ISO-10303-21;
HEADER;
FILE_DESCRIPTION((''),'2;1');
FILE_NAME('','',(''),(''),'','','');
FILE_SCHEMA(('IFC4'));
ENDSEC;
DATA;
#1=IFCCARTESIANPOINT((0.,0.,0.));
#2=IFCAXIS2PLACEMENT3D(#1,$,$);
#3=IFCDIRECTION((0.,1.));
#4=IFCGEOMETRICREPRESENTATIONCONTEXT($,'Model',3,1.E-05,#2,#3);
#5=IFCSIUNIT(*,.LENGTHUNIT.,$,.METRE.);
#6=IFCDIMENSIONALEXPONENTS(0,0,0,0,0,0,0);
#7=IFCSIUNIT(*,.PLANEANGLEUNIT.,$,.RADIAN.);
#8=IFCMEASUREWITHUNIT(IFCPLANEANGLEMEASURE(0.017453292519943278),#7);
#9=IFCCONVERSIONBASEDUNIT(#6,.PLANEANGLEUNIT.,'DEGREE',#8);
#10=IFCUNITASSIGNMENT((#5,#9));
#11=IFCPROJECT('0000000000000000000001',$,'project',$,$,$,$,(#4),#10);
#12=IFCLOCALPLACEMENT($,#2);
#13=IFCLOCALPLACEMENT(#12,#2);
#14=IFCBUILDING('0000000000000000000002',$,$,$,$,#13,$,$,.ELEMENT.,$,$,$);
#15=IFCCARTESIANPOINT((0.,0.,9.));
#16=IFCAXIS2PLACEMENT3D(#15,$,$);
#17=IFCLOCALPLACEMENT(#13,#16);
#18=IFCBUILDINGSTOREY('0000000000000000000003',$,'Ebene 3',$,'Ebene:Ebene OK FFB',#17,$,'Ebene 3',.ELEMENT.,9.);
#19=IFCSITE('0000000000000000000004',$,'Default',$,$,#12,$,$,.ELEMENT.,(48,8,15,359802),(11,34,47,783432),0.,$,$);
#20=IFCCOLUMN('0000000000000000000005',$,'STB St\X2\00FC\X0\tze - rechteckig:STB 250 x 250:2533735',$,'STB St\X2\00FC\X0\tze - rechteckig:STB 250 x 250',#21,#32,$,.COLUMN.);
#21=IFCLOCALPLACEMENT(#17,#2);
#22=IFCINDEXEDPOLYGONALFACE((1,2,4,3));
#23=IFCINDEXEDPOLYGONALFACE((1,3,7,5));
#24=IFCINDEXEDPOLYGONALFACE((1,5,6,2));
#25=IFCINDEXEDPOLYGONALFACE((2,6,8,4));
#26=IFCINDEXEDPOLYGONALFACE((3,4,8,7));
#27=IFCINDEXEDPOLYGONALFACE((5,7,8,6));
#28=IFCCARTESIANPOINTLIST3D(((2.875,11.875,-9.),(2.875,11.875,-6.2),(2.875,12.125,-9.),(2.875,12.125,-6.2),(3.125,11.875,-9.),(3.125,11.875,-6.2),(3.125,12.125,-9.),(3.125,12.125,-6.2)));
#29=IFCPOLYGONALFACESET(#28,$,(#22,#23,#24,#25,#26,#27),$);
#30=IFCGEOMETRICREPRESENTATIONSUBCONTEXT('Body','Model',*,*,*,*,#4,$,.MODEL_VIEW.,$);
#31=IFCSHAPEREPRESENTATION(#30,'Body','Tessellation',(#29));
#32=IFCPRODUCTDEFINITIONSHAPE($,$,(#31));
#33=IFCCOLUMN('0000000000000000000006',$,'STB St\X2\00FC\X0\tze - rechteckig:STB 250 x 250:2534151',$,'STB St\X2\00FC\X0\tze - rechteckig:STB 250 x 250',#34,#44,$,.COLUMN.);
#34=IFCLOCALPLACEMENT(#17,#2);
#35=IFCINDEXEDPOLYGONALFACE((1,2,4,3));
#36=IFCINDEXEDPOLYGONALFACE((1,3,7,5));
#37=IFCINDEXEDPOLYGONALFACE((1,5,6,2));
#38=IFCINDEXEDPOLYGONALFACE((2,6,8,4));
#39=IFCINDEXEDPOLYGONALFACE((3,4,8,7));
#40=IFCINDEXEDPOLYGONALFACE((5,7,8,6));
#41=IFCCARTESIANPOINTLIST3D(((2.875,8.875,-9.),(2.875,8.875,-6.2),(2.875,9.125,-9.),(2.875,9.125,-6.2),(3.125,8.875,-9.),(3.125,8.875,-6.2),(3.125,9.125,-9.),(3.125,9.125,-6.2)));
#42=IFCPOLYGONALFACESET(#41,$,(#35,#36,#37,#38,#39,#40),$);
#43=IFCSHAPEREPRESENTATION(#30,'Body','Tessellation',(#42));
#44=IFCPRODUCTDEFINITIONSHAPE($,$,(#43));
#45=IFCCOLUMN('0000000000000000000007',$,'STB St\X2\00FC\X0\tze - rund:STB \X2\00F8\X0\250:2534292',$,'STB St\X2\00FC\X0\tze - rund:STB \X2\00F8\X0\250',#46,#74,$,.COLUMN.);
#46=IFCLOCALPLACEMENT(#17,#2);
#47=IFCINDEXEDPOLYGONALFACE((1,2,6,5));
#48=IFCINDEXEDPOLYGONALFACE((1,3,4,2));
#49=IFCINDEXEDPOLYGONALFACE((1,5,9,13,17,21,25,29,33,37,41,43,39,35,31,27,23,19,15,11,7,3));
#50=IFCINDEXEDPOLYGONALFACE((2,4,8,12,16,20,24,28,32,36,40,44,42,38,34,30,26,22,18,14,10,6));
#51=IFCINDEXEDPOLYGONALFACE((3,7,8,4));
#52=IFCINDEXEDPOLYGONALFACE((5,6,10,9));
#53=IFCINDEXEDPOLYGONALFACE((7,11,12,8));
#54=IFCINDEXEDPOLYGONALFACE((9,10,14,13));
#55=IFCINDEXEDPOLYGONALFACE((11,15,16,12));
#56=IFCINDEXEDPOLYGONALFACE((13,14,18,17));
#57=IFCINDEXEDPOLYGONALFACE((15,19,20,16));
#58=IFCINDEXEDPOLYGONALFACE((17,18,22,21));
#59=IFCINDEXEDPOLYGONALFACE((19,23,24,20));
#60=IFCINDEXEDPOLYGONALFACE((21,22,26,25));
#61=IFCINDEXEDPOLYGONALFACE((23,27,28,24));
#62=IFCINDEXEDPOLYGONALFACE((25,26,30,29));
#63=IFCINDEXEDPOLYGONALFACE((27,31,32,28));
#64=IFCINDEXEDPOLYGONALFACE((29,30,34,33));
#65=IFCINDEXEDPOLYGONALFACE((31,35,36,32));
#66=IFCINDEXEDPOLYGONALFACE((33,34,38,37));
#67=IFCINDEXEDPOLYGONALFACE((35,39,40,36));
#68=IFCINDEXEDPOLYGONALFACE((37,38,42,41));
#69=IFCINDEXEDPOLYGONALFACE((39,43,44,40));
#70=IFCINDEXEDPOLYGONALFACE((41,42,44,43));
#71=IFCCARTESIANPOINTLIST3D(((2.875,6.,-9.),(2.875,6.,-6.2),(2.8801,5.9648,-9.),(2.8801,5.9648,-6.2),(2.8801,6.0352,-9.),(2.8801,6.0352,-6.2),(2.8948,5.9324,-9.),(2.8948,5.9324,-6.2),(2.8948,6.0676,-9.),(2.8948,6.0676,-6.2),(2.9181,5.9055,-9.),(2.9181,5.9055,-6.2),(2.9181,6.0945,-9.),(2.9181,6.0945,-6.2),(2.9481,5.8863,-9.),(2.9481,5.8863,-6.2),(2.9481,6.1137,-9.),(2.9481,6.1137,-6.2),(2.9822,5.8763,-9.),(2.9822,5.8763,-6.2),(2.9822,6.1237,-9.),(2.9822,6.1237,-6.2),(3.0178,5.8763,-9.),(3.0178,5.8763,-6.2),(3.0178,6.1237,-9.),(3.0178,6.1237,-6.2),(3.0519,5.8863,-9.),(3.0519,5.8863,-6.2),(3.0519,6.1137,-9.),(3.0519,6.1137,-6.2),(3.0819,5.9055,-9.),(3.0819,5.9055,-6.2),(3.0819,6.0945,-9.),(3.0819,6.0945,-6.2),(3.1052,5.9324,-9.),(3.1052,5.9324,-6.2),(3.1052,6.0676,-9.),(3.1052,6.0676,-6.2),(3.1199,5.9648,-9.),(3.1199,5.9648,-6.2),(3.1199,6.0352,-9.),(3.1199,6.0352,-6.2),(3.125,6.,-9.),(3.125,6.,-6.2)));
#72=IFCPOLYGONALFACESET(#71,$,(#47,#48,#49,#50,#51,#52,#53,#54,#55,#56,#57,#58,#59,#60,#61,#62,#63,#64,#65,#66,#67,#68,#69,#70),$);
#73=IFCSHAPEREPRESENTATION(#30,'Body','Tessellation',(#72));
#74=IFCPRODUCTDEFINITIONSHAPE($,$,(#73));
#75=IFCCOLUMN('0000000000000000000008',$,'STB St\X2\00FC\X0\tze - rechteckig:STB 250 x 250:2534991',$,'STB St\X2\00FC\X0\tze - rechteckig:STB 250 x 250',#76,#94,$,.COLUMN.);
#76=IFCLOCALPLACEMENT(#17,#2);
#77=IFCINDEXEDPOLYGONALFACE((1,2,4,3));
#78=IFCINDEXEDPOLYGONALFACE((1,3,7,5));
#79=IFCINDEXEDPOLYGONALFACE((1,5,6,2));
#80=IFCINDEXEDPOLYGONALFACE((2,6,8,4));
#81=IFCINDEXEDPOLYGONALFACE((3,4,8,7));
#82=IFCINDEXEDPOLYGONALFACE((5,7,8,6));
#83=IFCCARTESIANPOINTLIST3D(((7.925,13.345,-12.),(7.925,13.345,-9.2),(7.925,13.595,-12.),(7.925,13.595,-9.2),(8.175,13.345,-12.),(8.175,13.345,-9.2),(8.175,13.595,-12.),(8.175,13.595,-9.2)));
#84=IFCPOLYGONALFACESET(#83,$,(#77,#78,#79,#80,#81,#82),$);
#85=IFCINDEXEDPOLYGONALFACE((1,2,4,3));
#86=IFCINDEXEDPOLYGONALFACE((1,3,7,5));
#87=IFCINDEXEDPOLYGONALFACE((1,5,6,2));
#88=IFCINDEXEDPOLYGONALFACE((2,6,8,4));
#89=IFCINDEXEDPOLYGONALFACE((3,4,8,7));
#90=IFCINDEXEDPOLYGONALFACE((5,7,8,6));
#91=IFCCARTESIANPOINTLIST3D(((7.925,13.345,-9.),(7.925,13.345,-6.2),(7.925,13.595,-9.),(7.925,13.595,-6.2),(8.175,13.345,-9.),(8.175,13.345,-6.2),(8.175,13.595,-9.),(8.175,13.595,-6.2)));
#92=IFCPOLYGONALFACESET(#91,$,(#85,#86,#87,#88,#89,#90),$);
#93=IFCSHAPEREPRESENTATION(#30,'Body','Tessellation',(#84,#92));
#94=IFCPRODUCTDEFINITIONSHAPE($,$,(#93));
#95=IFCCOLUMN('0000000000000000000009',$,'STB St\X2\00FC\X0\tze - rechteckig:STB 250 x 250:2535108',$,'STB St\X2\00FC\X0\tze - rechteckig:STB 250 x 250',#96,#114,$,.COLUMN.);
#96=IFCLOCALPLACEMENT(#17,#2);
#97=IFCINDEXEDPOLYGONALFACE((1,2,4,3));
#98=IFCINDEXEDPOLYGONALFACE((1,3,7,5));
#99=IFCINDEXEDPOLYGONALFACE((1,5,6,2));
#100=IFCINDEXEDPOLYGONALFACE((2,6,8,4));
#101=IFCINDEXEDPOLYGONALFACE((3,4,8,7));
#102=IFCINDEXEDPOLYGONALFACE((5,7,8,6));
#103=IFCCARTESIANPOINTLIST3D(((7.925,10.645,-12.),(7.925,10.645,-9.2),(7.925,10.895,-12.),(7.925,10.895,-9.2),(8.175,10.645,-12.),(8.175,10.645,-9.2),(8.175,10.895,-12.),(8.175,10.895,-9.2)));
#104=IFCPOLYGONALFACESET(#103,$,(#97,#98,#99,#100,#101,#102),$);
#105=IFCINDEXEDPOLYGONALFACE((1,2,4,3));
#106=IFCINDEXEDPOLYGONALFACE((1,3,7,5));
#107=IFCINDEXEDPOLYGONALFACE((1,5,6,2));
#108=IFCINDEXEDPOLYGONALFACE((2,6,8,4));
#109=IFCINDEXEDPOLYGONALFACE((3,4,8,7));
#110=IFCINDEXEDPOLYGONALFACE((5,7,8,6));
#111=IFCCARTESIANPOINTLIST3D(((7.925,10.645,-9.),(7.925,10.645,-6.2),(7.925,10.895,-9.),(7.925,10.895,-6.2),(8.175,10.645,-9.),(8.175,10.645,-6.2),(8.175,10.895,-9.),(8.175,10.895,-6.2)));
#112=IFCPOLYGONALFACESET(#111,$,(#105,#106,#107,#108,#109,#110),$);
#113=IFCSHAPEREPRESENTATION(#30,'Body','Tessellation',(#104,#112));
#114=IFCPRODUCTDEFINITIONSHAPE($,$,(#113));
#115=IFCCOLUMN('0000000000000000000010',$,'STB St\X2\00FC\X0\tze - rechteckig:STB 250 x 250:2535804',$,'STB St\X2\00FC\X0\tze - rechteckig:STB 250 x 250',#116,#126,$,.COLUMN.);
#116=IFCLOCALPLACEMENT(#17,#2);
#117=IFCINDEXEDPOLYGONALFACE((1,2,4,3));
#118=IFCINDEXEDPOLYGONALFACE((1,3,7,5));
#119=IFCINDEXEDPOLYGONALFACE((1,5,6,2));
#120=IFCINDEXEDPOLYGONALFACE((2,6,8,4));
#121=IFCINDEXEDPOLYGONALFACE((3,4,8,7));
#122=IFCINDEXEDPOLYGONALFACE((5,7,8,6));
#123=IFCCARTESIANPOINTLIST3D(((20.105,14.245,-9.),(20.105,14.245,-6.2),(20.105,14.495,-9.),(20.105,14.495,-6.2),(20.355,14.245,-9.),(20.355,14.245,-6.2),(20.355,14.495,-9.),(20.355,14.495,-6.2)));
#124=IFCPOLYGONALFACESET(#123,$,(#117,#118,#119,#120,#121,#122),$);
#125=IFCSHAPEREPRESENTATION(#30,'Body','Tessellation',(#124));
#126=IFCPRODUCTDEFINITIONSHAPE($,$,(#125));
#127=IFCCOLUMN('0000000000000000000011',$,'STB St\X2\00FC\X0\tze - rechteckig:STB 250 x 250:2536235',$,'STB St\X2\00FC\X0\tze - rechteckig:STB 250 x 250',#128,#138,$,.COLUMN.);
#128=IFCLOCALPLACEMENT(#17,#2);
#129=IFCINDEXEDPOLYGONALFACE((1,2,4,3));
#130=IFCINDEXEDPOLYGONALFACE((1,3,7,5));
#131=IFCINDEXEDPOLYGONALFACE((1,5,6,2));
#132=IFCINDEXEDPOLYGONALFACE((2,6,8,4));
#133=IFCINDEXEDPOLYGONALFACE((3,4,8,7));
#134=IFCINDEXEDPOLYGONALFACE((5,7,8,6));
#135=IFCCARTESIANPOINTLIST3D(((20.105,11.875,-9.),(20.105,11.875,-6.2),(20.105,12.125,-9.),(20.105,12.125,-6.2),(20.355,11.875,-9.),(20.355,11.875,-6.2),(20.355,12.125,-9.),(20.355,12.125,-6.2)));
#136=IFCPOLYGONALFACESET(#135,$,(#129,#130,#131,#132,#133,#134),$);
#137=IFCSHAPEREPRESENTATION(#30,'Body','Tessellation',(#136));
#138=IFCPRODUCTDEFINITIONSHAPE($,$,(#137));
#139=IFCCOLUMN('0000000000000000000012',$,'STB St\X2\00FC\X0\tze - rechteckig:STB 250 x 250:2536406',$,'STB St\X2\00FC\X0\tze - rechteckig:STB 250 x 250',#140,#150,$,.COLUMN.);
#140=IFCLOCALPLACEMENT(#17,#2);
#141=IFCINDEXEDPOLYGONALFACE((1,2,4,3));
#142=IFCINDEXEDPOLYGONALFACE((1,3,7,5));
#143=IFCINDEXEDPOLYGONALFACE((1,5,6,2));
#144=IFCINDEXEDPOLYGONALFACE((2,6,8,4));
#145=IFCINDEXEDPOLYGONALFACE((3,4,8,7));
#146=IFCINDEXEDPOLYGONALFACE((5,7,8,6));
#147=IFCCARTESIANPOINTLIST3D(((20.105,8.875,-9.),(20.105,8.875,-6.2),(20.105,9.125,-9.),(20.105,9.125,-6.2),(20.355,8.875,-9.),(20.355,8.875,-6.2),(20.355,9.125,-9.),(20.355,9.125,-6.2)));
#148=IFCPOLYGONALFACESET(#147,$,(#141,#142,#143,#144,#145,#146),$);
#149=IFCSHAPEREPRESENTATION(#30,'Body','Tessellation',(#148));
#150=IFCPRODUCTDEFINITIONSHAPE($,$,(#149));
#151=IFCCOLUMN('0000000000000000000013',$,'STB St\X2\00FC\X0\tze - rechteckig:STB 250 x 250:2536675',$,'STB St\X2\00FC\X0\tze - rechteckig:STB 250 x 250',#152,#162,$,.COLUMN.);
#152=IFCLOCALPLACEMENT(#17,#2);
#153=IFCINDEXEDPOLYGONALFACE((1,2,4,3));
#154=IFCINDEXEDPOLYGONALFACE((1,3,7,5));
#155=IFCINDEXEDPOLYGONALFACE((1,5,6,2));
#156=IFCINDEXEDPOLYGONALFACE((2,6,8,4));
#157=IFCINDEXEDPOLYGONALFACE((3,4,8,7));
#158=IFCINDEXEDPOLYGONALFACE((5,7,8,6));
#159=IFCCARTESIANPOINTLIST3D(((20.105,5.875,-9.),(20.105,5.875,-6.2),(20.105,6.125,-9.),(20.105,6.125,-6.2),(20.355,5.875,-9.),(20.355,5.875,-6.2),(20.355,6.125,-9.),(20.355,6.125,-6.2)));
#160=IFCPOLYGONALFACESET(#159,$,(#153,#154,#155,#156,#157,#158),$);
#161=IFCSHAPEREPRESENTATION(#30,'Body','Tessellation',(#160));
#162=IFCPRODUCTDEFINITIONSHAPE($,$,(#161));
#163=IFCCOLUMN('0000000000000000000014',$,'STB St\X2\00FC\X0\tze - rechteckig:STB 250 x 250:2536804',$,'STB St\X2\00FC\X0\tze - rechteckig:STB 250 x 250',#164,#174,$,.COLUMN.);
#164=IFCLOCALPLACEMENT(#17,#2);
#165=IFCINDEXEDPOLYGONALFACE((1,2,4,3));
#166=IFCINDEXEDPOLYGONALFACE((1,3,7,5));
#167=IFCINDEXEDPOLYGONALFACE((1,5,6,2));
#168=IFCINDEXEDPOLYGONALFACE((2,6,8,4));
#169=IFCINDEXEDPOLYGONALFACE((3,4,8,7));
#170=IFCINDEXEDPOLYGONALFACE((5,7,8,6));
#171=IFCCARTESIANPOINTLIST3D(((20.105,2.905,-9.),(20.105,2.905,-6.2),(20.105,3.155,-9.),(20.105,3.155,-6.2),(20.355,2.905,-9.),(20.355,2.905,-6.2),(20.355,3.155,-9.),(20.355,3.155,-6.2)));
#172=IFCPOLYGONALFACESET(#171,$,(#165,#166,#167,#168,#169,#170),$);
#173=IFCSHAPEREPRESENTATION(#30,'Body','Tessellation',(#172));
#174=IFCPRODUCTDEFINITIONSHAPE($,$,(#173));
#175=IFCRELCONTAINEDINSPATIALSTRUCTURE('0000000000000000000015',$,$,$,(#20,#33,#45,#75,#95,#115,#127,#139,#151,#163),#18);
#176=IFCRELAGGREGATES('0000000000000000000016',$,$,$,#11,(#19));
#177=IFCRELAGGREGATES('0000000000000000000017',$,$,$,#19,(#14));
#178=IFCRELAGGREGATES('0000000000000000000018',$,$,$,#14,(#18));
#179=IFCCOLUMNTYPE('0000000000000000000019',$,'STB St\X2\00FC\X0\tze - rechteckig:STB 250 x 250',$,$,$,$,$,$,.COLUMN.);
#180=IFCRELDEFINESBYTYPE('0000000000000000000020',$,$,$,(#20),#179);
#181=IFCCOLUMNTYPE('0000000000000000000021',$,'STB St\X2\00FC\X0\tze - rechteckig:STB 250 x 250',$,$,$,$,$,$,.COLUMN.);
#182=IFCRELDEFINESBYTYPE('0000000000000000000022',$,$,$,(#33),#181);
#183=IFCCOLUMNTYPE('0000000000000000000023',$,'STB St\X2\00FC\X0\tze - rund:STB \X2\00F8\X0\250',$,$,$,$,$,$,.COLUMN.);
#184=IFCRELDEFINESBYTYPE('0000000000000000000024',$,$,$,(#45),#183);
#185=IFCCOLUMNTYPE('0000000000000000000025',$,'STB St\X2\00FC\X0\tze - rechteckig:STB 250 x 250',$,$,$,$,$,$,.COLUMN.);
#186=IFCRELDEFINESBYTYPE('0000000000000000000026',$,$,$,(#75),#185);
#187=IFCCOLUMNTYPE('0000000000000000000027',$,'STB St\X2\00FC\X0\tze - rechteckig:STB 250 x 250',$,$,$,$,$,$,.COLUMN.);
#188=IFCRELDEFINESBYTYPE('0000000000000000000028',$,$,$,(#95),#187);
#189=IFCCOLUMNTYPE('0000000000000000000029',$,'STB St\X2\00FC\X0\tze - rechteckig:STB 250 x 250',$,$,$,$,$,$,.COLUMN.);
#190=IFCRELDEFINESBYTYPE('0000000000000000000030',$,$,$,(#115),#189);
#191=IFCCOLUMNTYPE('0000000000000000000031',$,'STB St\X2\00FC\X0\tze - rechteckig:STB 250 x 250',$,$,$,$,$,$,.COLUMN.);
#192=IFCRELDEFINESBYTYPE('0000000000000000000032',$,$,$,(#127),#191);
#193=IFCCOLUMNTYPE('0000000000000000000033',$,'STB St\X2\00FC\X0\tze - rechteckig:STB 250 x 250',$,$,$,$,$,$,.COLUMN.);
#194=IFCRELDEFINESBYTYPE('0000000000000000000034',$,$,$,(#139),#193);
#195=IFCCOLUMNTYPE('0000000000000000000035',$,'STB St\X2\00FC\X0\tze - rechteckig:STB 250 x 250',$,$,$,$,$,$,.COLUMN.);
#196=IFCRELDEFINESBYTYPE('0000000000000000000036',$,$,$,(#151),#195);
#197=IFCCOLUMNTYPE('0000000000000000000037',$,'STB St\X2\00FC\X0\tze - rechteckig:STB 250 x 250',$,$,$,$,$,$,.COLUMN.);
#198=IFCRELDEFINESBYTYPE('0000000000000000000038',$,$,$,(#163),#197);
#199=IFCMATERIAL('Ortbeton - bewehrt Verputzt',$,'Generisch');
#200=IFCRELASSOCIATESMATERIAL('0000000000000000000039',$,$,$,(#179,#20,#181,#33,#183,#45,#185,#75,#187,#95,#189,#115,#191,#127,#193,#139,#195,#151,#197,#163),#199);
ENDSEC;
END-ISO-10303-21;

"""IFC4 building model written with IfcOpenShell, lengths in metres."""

from ifc_helpers import new_model, entity, si_unit, converted_unit, direction, frame, origin, place, context, subcontext, project, spatial, arc, indexed_curve, outline, extrude, source, transform, mapped, material, type_object, type_shapes, element, save


model = new_model("IFC4")

# Units and contexts
model_context = context("Model", 3, precision=1e-05, world=origin(), true_north=direction((0.0, 1.0)))
body_context = subcontext(model_context, "Body", "Model", "MODEL_VIEW")
ifc_project = project(units=[si_unit("LENGTHUNIT", "METRE"), converted_unit("PLANEANGLEUNIT", "DEGREE", entity("IfcPlaneAngleMeasure", 0.017453292519943278), si_unit("PLANEANGLEUNIT", "RADIAN"), dimensions=[0, 0, 0, 0, 0, 0, 0])], contexts=[model_context])

# Site, building, storey
site_placement = place(None, origin())
site = spatial("IfcSite", under=ifc_project, at=site_placement, Name="Default", CompositionType="ELEMENT", RefLatitude=(48, 8, 15, 359802), RefLongitude=(11, 34, 47, 783432), RefElevation=0.0)
building_placement = place(site_placement, origin())
building = spatial("IfcBuilding", under=site, at=building_placement, CompositionType="ELEMENT")
storey_placement = place(building_placement, frame((0.0, 0.0, 9.0)))
storey = spatial("IfcBuildingStorey", under=building, at=storey_placement, Name="Ebene 3", ObjectType="Ebene:Ebene OK FFB", LongName="Ebene 3", CompositionType="ELEMENT", Elevation=9.0)

# Columns
ifc_material_1 = material(Name="Ortbeton - bewehrt Verputzt", Category="Generisch")
column_type_1 = type_object("IfcColumnType", Name="STB Stütze - rechteckig:STB 250 x 250", PredefinedType="COLUMN", material=ifc_material_1)
shared_shape_1 = source(origin(), body_context, "Body", "SweptSolid", [
    extrude(outline(indexed_curve([(-0.125, -0.125), (0.125, -0.125), (0.125, 0.125), (-0.125, 0.125), (-0.125, -0.125)], self_intersect=False)), frame((3.0, 12.0, 0.0), z_axis=(0.0, 0.0, 1.0), x_axis=(-1.0, 0.0, 0.0)), (0.0, 0.0, 1.0), 2.8),
])
type_shapes(column_type_1, [shared_shape_1])
column_1_placement = place(storey_placement, frame((0.0, 0.0, -9.0)))
element("IfcColumn", 1, at=column_1_placement, inside=storey, type_object=column_type_1, material=ifc_material_1, Name="STB Stütze - rechteckig:STB 250 x 250:2533735", ObjectType="STB Stütze - rechteckig:STB 250 x 250", PredefinedType="COLUMN", context=body_context, shape_type="MappedRepresentation", body=[
    mapped(shared_shape_1, transform((0.0, 0.0, 0.0), scale=1.0)),
])
column_type_2 = type_object("IfcColumnType", Name="STB Stütze - rechteckig:STB 250 x 250", PredefinedType="COLUMN", material=ifc_material_1)
shared_shape_2 = source(origin(), body_context, "Body", "SweptSolid", [
    extrude(outline(indexed_curve([(-0.125, -0.125), (0.125, -0.125), (0.125, 0.125), (-0.125, 0.125), (-0.125, -0.125)], self_intersect=False)), frame((3.0, 9.0, 0.0), z_axis=(0.0, 0.0, 1.0), x_axis=(-1.0, 0.0, 0.0)), (0.0, 0.0, 1.0), 2.8),
])
type_shapes(column_type_2, [shared_shape_2])
column_2_placement = place(storey_placement, frame((0.0, 0.0, -9.0)))
element("IfcColumn", 2, at=column_2_placement, inside=storey, type_object=column_type_2, material=ifc_material_1, Name="STB Stütze - rechteckig:STB 250 x 250:2534151", ObjectType="STB Stütze - rechteckig:STB 250 x 250", PredefinedType="COLUMN", context=body_context, shape_type="MappedRepresentation", body=[
    mapped(shared_shape_2, transform((0.0, 0.0, 0.0), scale=1.0)),
])
column_type_3 = type_object("IfcColumnType", Name="STB Stütze - rund:STB ø250", PredefinedType="COLUMN", material=ifc_material_1)
shared_shape_3 = source(origin(), body_context, "Body", "SweptSolid", [
    extrude(outline(indexed_curve([(0.125, 0.0), (0.0, 0.125), (-0.125, 0.0), (0.0, -0.125)], segments=[arc(1, 2, 3), arc(3, 4, 1)], self_intersect=False)), frame((3.0, 6.0, 0.0)), (0.0, 0.0, 1.0), 2.8),
])
type_shapes(column_type_3, [shared_shape_3])
column_3_placement = place(storey_placement, frame((0.0, 0.0, -9.0)))
element("IfcColumn", 3, at=column_3_placement, inside=storey, type_object=column_type_3, material=ifc_material_1, Name="STB Stütze - rund:STB ø250:2534292", ObjectType="STB Stütze - rund:STB ø250", PredefinedType="COLUMN", context=body_context, shape_type="MappedRepresentation", body=[
    mapped(shared_shape_3, transform((0.0, 0.0, 0.0), scale=1.0)),
])
column_type_4 = type_object("IfcColumnType", Name="STB Stütze - rechteckig:STB 250 x 250", PredefinedType="COLUMN", material=ifc_material_1)
shared_shape_4 = source(origin(), body_context, "Body", "SweptSolid", [
    extrude(outline(indexed_curve([(-0.125, -0.125), (0.125, -0.125), (0.125, 0.125), (-0.125, 0.125), (-0.125, -0.125)], self_intersect=False)), frame((8.05, 13.47, -3.0), z_axis=(0.0, 0.0, 1.0), x_axis=(-1.0, 0.0, 0.0)), (0.0, 0.0, 1.0), 2.8),
    extrude(outline(indexed_curve([(-0.125, -0.125), (0.125, -0.125), (0.125, 0.125), (-0.125, 0.125), (-0.125, -0.125)], self_intersect=False)), frame((8.05, 13.47, 0.0), z_axis=(0.0, 0.0, 1.0), x_axis=(0.0, -1.0, 0.0)), (0.0, 0.0, 1.0), 2.8),
])
type_shapes(column_type_4, [shared_shape_4])
column_4_placement = place(storey_placement, frame((0.0, 0.0, -9.0)))
element("IfcColumn", 4, at=column_4_placement, inside=storey, type_object=column_type_4, material=ifc_material_1, Name="STB Stütze - rechteckig:STB 250 x 250:2534991", ObjectType="STB Stütze - rechteckig:STB 250 x 250", PredefinedType="COLUMN", context=body_context, shape_type="MappedRepresentation", body=[
    mapped(shared_shape_4, transform((0.0, 0.0, 0.0), scale=1.0)),
])
column_type_5 = type_object("IfcColumnType", Name="STB Stütze - rechteckig:STB 250 x 250", PredefinedType="COLUMN", material=ifc_material_1)
shared_shape_5 = source(origin(), body_context, "Body", "SweptSolid", [
    extrude(outline(indexed_curve([(-0.125, -0.125), (0.125, -0.125), (0.125, 0.125), (-0.125, 0.125), (-0.125, -0.125)], self_intersect=False)), frame((8.05, 10.77, -3.0), z_axis=(0.0, 0.0, 1.0), x_axis=(-1.0, 0.0, 0.0)), (0.0, 0.0, 1.0), 2.8),
    extrude(outline(indexed_curve([(-0.125, -0.125), (0.125, -0.125), (0.125, 0.125), (-0.125, 0.125), (-0.125, -0.125)], self_intersect=False)), frame((8.05, 10.77, 0.0), z_axis=(0.0, 0.0, 1.0), x_axis=(0.0, -1.0, 0.0)), (0.0, 0.0, 1.0), 2.8),
])
type_shapes(column_type_5, [shared_shape_5])
column_5_placement = place(storey_placement, frame((0.0, 0.0, -9.0)))
element("IfcColumn", 5, at=column_5_placement, inside=storey, type_object=column_type_5, material=ifc_material_1, Name="STB Stütze - rechteckig:STB 250 x 250:2535108", ObjectType="STB Stütze - rechteckig:STB 250 x 250", PredefinedType="COLUMN", context=body_context, shape_type="MappedRepresentation", body=[
    mapped(shared_shape_5, transform((0.0, 0.0, 0.0), scale=1.0)),
])
column_type_6 = type_object("IfcColumnType", Name="STB Stütze - rechteckig:STB 250 x 250", PredefinedType="COLUMN", material=ifc_material_1)
shared_shape_6 = source(origin(), body_context, "Body", "SweptSolid", [
    extrude(outline(indexed_curve([(-0.125, -0.125), (0.125, -0.125), (0.125, 0.125), (-0.125, 0.125), (-0.125, -0.125)], self_intersect=False)), frame((20.23, 14.37, 0.0), z_axis=(0.0, 0.0, 1.0), x_axis=(-1.0, 0.0, 0.0)), (0.0, 0.0, 1.0), 2.8),
])
type_shapes(column_type_6, [shared_shape_6])
column_6_placement = place(storey_placement, frame((0.0, 0.0, -9.0)))
element("IfcColumn", 6, at=column_6_placement, inside=storey, type_object=column_type_6, material=ifc_material_1, Name="STB Stütze - rechteckig:STB 250 x 250:2535804", ObjectType="STB Stütze - rechteckig:STB 250 x 250", PredefinedType="COLUMN", context=body_context, shape_type="MappedRepresentation", body=[
    mapped(shared_shape_6, transform((0.0, 0.0, 0.0), scale=1.0)),
])
column_type_7 = type_object("IfcColumnType", Name="STB Stütze - rechteckig:STB 250 x 250", PredefinedType="COLUMN", material=ifc_material_1)
shared_shape_7 = source(origin(), body_context, "Body", "SweptSolid", [
    extrude(outline(indexed_curve([(-0.125, -0.125), (0.125, -0.125), (0.125, 0.125), (-0.125, 0.125), (-0.125, -0.125)], self_intersect=False)), frame((20.23, 12.0, 0.0), z_axis=(0.0, 0.0, 1.0), x_axis=(-1.0, 0.0, 0.0)), (0.0, 0.0, 1.0), 2.8),
])
type_shapes(column_type_7, [shared_shape_7])
column_7_placement = place(storey_placement, frame((0.0, 0.0, -9.0)))
element("IfcColumn", 7, at=column_7_placement, inside=storey, type_object=column_type_7, material=ifc_material_1, Name="STB Stütze - rechteckig:STB 250 x 250:2536235", ObjectType="STB Stütze - rechteckig:STB 250 x 250", PredefinedType="COLUMN", context=body_context, shape_type="MappedRepresentation", body=[
    mapped(shared_shape_7, transform((0.0, 0.0, 0.0), scale=1.0)),
])
column_type_8 = type_object("IfcColumnType", Name="STB Stütze - rechteckig:STB 250 x 250", PredefinedType="COLUMN", material=ifc_material_1)
shared_shape_8 = source(origin(), body_context, "Body", "SweptSolid", [
    extrude(outline(indexed_curve([(-0.125, -0.125), (0.125, -0.125), (0.125, 0.125), (-0.125, 0.125), (-0.125, -0.125)], self_intersect=False)), frame((20.23, 9.0, 0.0), z_axis=(0.0, 0.0, 1.0), x_axis=(-1.0, 0.0, 0.0)), (0.0, 0.0, 1.0), 2.8),
])
type_shapes(column_type_8, [shared_shape_8])
column_8_placement = place(storey_placement, frame((0.0, 0.0, -9.0)))
element("IfcColumn", 8, at=column_8_placement, inside=storey, type_object=column_type_8, material=ifc_material_1, Name="STB Stütze - rechteckig:STB 250 x 250:2536406", ObjectType="STB Stütze - rechteckig:STB 250 x 250", PredefinedType="COLUMN", context=body_context, shape_type="MappedRepresentation", body=[
    mapped(shared_shape_8, transform((0.0, 0.0, 0.0), scale=1.0)),
])
column_type_9 = type_object("IfcColumnType", Name="STB Stütze - rechteckig:STB 250 x 250", PredefinedType="COLUMN", material=ifc_material_1)
shared_shape_9 = source(origin(), body_context, "Body", "SweptSolid", [
    extrude(outline(indexed_curve([(-0.125, -0.125), (0.125, -0.125), (0.125, 0.125), (-0.125, 0.125), (-0.125, -0.125)], self_intersect=False)), frame((20.23, 6.0, 0.0), z_axis=(0.0, 0.0, 1.0), x_axis=(-1.0, 0.0, 0.0)), (0.0, 0.0, 1.0), 2.8),
])
type_shapes(column_type_9, [shared_shape_9])
column_9_placement = place(storey_placement, frame((0.0, 0.0, -9.0)))
element("IfcColumn", 9, at=column_9_placement, inside=storey, type_object=column_type_9, material=ifc_material_1, Name="STB Stütze - rechteckig:STB 250 x 250:2536675", ObjectType="STB Stütze - rechteckig:STB 250 x 250", PredefinedType="COLUMN", context=body_context, shape_type="MappedRepresentation", body=[
    mapped(shared_shape_9, transform((0.0, 0.0, 0.0), scale=1.0)),
])
column_type_10 = type_object("IfcColumnType", Name="STB Stütze - rechteckig:STB 250 x 250", PredefinedType="COLUMN", material=ifc_material_1)
shared_shape_10 = source(origin(), body_context, "Body", "SweptSolid", [
    extrude(outline(indexed_curve([(-0.125, -0.125), (0.125, -0.125), (0.125, 0.125), (-0.125, 0.125), (-0.125, -0.125)], self_intersect=False)), frame((20.23, 3.03, 0.0), z_axis=(0.0, 0.0, 1.0), x_axis=(-1.0, 0.0, 0.0)), (0.0, 0.0, 1.0), 2.8),
])
type_shapes(column_type_10, [shared_shape_10])
column_10_placement = place(storey_placement, frame((0.0, 0.0, -9.0)))
element("IfcColumn", 10, at=column_10_placement, inside=storey, type_object=column_type_10, material=ifc_material_1, Name="STB Stütze - rechteckig:STB 250 x 250:2536804", ObjectType="STB Stütze - rechteckig:STB 250 x 250", PredefinedType="COLUMN", context=body_context, shape_type="MappedRepresentation", body=[
    mapped(shared_shape_10, transform((0.0, 0.0, 0.0), scale=1.0)),
])

save(model, "model.ifc")
